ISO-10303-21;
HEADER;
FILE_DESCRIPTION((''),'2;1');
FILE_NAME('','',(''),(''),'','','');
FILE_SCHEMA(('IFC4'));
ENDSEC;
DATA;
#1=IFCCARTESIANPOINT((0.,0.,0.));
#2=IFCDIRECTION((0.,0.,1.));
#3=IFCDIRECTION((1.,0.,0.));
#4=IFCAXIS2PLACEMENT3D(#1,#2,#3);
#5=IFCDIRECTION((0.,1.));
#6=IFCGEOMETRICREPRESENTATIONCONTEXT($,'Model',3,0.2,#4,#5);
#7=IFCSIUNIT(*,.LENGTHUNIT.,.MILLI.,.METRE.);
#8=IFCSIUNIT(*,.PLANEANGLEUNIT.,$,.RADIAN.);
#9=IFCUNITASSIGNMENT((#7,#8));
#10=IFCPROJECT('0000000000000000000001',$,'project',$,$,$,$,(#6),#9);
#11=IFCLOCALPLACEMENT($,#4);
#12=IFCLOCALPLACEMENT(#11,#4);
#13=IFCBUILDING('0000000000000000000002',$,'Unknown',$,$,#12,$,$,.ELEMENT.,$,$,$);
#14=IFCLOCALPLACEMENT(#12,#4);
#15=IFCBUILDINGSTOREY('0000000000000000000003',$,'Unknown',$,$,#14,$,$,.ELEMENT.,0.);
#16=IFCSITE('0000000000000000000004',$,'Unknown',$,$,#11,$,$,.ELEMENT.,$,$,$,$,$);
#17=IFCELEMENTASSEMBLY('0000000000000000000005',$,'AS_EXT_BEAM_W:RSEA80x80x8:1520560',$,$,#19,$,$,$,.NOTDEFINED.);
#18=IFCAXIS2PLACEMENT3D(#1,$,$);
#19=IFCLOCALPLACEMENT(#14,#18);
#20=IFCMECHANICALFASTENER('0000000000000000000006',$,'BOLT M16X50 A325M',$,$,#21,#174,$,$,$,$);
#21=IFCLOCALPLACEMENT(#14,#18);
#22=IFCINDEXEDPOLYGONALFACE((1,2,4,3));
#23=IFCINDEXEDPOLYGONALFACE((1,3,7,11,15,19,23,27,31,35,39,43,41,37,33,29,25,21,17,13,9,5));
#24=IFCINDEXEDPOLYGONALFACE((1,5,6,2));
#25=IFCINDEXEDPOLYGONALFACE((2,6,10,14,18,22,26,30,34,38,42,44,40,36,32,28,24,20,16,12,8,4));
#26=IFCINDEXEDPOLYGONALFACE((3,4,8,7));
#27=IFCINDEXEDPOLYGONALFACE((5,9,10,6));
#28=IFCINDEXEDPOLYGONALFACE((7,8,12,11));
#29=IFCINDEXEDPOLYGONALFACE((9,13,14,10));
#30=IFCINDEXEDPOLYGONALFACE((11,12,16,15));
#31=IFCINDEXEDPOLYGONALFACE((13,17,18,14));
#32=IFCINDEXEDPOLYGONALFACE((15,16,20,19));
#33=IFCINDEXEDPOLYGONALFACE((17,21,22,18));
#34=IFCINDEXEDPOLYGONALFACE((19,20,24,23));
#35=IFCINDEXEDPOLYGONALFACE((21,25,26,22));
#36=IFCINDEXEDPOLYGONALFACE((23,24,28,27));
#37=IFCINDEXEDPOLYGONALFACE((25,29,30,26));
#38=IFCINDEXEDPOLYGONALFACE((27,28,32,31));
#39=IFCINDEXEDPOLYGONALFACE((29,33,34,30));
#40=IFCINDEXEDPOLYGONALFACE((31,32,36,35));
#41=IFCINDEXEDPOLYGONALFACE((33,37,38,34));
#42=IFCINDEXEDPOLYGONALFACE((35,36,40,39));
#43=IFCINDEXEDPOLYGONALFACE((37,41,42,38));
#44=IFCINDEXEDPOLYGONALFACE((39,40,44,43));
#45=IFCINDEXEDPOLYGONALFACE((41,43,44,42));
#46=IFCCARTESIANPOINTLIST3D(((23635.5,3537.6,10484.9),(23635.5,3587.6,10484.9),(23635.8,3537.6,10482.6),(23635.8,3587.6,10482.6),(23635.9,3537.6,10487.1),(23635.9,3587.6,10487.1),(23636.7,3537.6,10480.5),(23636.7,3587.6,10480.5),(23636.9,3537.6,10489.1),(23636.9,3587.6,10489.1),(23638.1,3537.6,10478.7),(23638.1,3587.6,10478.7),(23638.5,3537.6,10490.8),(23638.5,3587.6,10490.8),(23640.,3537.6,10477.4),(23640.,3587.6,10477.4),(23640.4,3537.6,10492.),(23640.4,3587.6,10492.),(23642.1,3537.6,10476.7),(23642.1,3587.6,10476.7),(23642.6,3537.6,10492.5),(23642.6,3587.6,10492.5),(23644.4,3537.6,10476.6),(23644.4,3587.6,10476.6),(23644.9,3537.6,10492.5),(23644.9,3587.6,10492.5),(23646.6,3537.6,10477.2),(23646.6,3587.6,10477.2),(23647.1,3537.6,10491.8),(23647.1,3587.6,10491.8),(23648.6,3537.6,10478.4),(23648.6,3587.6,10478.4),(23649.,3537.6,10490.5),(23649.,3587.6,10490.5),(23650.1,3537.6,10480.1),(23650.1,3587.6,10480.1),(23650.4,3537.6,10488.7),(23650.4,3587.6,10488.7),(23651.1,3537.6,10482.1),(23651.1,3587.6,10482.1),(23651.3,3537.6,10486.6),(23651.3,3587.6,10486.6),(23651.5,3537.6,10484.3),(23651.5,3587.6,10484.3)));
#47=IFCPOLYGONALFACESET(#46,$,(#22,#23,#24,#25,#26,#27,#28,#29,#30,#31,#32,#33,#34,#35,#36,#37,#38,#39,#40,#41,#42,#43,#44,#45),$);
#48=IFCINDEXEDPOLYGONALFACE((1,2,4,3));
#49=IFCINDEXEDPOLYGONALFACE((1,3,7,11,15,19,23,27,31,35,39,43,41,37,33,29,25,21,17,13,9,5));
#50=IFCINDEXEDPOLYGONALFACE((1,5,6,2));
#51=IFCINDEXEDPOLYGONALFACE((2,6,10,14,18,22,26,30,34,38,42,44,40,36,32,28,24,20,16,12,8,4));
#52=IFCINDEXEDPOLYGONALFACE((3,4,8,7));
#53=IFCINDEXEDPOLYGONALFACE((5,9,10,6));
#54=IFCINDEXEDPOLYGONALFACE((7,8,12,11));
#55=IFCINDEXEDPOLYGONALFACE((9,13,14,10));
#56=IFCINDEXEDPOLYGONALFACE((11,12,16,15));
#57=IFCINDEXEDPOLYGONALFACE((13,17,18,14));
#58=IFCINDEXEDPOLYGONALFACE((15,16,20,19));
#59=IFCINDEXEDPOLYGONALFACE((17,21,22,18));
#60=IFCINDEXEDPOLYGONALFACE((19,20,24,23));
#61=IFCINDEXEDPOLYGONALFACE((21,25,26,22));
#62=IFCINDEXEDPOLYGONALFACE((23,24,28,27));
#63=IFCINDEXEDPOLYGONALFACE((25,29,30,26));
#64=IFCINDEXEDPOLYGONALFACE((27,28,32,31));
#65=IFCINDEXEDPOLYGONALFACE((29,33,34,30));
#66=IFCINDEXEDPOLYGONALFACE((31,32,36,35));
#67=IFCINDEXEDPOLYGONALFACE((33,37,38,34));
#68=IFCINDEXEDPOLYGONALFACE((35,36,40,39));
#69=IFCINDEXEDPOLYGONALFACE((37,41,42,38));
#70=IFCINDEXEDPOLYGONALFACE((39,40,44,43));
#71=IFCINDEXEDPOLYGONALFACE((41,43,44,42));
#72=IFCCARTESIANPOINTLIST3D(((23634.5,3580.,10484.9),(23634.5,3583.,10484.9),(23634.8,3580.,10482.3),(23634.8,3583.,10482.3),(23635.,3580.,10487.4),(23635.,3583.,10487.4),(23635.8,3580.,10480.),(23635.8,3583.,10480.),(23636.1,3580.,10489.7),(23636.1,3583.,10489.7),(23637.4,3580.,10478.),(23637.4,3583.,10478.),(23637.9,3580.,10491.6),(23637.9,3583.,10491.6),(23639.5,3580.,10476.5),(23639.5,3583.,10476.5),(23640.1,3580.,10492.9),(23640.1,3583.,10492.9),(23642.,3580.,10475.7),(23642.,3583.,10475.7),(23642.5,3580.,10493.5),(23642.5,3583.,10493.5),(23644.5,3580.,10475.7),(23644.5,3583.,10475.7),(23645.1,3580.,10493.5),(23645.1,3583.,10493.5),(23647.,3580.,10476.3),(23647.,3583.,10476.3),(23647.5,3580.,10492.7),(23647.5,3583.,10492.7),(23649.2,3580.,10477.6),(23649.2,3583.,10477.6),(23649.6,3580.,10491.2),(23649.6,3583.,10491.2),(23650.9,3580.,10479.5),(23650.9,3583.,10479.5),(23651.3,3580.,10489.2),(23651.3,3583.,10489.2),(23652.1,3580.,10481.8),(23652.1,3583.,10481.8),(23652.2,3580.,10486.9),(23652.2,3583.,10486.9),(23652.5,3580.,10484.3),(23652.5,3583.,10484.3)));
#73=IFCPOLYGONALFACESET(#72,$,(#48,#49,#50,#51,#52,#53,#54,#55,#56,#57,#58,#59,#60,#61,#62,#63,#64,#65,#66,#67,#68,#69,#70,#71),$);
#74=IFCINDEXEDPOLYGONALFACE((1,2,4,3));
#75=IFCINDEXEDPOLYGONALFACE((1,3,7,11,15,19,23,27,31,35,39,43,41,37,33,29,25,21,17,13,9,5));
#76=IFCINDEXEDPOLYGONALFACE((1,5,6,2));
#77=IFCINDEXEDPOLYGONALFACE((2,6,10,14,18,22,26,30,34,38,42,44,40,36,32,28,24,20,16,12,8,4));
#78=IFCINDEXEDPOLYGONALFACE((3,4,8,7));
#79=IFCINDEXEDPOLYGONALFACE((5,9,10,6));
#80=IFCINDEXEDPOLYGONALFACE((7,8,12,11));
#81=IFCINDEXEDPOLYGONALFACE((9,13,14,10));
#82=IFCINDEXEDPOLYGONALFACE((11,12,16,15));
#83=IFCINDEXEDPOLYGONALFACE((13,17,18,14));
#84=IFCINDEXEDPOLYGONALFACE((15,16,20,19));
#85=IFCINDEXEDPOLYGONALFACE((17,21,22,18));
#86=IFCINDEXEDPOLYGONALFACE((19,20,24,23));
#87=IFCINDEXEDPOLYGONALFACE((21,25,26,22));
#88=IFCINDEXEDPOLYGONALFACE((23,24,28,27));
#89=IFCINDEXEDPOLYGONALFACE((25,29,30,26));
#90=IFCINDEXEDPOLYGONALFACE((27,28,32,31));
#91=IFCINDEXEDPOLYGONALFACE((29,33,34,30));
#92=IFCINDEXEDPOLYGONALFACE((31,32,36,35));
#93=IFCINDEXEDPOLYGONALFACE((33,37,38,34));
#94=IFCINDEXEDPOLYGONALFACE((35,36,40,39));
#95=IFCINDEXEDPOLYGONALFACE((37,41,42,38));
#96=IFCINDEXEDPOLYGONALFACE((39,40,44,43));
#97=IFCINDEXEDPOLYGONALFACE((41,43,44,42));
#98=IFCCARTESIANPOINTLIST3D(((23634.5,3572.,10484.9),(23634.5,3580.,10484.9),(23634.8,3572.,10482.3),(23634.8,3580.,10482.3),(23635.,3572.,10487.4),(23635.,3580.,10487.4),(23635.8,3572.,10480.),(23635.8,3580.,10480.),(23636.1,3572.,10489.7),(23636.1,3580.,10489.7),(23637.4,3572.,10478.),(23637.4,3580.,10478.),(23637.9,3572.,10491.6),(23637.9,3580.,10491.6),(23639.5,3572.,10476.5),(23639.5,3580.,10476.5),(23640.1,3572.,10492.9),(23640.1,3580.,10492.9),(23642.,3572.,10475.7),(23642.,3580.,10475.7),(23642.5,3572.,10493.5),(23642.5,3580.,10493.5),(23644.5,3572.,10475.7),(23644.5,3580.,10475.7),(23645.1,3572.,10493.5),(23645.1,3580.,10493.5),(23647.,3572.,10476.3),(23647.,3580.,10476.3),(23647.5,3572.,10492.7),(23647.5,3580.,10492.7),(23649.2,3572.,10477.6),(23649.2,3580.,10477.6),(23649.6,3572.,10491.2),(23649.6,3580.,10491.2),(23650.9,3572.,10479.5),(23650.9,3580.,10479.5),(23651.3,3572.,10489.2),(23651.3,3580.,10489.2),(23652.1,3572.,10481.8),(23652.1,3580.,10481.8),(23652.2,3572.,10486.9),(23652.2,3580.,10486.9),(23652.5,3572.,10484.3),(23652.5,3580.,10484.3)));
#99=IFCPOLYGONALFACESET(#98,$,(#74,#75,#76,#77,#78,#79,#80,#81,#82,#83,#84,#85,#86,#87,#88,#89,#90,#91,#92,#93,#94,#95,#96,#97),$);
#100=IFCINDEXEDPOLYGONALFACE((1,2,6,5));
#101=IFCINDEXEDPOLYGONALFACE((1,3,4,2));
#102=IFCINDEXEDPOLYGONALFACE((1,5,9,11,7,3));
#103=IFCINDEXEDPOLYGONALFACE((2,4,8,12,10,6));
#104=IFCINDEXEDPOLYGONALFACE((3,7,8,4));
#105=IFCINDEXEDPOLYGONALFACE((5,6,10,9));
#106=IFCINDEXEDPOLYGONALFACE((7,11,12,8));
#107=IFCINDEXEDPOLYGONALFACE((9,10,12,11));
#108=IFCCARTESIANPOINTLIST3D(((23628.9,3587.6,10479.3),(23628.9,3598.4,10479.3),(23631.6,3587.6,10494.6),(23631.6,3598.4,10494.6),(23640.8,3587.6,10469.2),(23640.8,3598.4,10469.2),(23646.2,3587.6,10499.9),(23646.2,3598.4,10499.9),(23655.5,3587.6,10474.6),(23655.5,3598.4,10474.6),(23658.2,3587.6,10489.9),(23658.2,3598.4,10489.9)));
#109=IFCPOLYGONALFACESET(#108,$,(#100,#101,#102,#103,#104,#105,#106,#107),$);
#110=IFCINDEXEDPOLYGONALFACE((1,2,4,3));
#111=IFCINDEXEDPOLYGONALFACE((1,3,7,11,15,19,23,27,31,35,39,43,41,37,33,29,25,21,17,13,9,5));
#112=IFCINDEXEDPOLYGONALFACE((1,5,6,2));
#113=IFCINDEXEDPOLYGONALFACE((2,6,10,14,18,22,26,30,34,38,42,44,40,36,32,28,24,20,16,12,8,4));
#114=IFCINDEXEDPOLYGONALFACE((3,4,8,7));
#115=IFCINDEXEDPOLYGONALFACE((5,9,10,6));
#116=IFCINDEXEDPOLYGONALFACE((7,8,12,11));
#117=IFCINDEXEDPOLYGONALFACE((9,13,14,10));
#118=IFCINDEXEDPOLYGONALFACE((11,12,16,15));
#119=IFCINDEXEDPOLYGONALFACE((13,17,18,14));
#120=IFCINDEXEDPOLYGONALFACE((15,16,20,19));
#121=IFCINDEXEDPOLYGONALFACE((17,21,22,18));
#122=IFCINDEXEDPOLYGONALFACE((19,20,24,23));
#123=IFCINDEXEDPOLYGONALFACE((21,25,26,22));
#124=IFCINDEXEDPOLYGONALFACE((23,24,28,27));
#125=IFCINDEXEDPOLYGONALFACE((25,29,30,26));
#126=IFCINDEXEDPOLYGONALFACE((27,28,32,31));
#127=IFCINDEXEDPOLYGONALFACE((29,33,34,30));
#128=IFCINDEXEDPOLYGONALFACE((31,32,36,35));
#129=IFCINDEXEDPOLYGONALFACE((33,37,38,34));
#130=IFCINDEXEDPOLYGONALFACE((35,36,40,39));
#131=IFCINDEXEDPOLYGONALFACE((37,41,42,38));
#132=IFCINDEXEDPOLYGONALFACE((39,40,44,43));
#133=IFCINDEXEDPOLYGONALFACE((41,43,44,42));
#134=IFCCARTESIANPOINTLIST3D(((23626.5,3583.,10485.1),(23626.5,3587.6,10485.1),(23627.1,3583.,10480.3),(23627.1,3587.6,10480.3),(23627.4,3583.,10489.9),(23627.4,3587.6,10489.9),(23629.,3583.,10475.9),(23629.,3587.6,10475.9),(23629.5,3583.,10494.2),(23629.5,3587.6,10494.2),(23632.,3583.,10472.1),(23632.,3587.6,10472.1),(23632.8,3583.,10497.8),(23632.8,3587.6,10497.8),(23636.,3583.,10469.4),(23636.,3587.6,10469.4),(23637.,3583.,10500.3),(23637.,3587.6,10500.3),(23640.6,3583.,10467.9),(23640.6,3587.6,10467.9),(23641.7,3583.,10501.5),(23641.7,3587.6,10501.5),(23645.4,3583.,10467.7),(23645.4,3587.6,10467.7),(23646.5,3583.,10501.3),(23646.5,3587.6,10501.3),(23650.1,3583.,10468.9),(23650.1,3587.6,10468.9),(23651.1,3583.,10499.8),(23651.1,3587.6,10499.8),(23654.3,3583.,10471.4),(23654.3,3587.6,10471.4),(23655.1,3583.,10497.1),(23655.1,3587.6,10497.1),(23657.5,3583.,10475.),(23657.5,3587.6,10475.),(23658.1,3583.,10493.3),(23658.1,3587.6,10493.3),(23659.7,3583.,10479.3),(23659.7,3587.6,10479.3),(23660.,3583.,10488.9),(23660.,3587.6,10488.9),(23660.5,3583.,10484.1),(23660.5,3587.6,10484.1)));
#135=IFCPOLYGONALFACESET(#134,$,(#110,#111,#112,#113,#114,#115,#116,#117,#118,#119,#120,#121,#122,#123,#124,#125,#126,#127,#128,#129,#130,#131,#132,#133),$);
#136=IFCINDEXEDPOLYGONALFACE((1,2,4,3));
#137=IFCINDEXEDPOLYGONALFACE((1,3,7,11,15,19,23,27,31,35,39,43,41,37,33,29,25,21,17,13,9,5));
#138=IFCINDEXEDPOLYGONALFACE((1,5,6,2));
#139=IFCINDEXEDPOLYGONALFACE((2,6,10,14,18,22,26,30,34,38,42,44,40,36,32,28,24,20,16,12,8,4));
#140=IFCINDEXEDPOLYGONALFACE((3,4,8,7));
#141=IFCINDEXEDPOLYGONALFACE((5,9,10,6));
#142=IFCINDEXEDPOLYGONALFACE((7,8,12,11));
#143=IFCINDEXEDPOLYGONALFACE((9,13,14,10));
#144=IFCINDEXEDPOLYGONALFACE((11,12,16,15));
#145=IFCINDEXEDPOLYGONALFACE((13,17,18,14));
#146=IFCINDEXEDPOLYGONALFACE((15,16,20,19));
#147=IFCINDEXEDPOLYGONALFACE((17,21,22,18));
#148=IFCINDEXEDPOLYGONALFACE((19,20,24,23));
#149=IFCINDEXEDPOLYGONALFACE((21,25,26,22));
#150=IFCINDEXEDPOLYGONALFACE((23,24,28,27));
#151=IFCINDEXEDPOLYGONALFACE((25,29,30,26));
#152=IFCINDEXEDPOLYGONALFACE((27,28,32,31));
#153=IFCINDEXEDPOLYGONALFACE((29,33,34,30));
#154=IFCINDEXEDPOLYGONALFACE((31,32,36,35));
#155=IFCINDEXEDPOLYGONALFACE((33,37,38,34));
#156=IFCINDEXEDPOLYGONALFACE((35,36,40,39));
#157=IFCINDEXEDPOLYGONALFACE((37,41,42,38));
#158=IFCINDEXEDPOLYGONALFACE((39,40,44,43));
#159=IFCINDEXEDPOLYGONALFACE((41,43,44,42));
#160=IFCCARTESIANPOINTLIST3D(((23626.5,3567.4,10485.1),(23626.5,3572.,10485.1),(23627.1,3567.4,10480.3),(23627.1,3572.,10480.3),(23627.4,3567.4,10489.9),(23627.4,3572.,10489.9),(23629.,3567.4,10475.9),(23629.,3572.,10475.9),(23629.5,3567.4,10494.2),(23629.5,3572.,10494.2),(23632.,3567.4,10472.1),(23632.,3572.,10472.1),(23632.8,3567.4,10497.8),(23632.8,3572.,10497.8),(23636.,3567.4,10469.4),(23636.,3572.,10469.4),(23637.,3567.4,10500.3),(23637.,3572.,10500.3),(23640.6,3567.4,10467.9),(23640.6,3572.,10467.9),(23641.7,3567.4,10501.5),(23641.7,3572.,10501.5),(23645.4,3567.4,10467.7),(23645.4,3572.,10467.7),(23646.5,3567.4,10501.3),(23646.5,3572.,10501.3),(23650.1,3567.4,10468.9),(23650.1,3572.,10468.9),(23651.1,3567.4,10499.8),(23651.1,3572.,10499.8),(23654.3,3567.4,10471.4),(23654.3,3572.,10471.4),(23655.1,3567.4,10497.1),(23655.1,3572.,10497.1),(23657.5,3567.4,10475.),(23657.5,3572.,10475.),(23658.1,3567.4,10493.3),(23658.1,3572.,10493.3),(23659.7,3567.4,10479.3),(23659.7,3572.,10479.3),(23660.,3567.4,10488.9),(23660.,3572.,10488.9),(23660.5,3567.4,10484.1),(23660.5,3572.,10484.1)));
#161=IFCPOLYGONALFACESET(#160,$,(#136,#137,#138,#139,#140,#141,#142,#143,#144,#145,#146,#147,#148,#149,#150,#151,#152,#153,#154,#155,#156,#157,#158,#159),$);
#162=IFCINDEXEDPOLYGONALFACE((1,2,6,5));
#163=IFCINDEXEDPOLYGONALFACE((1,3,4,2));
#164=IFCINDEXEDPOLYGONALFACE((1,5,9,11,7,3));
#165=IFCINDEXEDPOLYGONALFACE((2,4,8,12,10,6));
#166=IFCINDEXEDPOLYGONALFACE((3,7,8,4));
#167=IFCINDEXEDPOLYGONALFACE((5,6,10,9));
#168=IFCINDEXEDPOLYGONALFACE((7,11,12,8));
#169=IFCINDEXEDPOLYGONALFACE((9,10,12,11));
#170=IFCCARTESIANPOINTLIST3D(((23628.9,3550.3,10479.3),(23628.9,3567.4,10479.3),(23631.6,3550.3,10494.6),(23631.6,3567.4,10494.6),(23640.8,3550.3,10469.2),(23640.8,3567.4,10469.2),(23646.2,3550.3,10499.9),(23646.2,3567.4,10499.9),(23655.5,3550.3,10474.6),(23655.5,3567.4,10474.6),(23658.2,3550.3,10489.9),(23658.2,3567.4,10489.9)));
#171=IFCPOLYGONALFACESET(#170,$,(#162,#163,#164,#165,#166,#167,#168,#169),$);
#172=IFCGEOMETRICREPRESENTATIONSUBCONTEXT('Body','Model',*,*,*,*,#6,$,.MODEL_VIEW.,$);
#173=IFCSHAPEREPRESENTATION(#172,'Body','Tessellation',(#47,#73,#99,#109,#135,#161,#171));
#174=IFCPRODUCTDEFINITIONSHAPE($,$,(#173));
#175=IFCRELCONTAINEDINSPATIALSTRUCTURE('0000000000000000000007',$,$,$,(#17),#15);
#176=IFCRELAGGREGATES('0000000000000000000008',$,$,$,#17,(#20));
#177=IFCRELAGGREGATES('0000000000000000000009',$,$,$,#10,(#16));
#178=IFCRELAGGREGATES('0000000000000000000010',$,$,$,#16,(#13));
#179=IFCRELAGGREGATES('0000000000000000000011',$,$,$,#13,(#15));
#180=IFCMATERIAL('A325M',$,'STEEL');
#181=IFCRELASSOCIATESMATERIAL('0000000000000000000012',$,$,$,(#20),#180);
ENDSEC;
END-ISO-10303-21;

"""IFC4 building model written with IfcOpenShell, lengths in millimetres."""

from ifc_helpers import new_model, si_unit, direction, frame, origin_with_axes, place, context, subcontext, project, spatial, line, arc, indexed_curve, outline, extrude, source, transform, mapped, material, element, aggregate, save


model = new_model("IFC4")

# Units and contexts
model_context = context("Model", 3, precision=0.2, world=origin_with_axes(), true_north=direction((0.0, 1.0)))
body_context = subcontext(model_context, "Body", "Model", "MODEL_VIEW")
ifc_project = project(units=[si_unit("LENGTHUNIT", "METRE", prefix="MILLI"), si_unit("PLANEANGLEUNIT", "RADIAN")], contexts=[model_context])

# Site, building, storey
site_placement = place(None, origin_with_axes())
site = spatial("IfcSite", under=ifc_project, at=site_placement, Name="Unknown", CompositionType="ELEMENT")
building_placement = place(site_placement, origin_with_axes())
building = spatial("IfcBuilding", under=site, at=building_placement, Name="Unknown", CompositionType="ELEMENT")
storey_placement = place(building_placement, origin_with_axes())
storey = spatial("IfcBuildingStorey", under=building, at=storey_placement, Name="Unknown", CompositionType="ELEMENT", Elevation=0.0)

# Element assembly
assembly_1_placement = place(storey_placement, frame((23581.1, 3540.0, 10490.5), z_axis=(0.0, -1.0, 0.0), x_axis=(0.984808, 0.0, -0.173648)))
assembly_1 = element("IfcElementAssembly", 1, at=assembly_1_placement, inside=storey, Name="AS_EXT_BEAM_W:RSEA80x80x8:1520560", PredefinedType="NOTDEFINED")

# Mechanical fastener
ifc_material_1 = material(Name="A325M", Category="STEEL")
shared_shape = source(origin_with_axes(), body_context, "Body", "SweptSolid", [
    extrude(outline(indexed_curve([(8.0, 0.0), (0.0, 8.0), (-8.0, 0.0), (0.0, -8.0)], segments=[arc(1, 2, 3), arc(3, 4, 1)])), frame((0.0, 0.0, 15.6), z_axis=(0.0, 0.0, -1.0), x_axis=(0.0, 1.0, 0.0)), (0.0, 0.0, 1.0), 50.0),
    extrude(outline(indexed_curve([(9.0, 0.0), (0.0, 9.0), (-9.0, 0.0), (0.0, -9.0)], segments=[arc(1, 2, 3), arc(3, 4, 1)])), frame((0.0, 0.0, 11.0), z_axis=(0.0, 0.0, -1.0), x_axis=(0.0, 1.0, 0.0)), (0.0, 0.0, 1.0), 3.0),
    extrude(outline(indexed_curve([(9.0, 0.0), (0.0, 9.0), (-9.0, 0.0), (0.0, -9.0)], segments=[arc(1, 2, 3), arc(3, 4, 1)])), frame((0.0, 0.0, 8.0), z_axis=(0.0, 0.0, -1.0), x_axis=(0.0, 1.0, 0.0)), (0.0, 0.0, 1.0), 8.0),
    extrude(outline(indexed_curve([(15.6, 0.0), (7.8, 13.5), (-7.8, 13.5), (-15.6, 0.0), (-7.8, -13.5), (7.8, -13.5)], segments=[line(1, 2, 3, 4, 5, 6, 1)])), frame((0.0, 0.0, 26.4), z_axis=(0.0, 0.0, -1.0), x_axis=(0.0, 1.0, 0.0)), (0.0, 0.0, 1.0), 10.8),
    extrude(outline(indexed_curve([(17.0, 0.0), (0.0, 17.0), (-17.0, 0.0), (0.0, -17.0)], segments=[arc(1, 2, 3), arc(3, 4, 1)])), frame((0.0, 0.0, 15.6), z_axis=(0.0, 0.0, -1.0), x_axis=(0.0, 1.0, 0.0)), (0.0, 0.0, 1.0), 4.6),
    extrude(outline(indexed_curve([(17.0, 0.0), (0.0, 17.0), (-17.0, 0.0), (0.0, -17.0)], segments=[arc(1, 2, 3), arc(3, 4, 1)])), frame((0.0, 0.0, 0.0), z_axis=(0.0, 0.0, -1.0), x_axis=(0.0, 1.0, 0.0)), (0.0, 0.0, 1.0), 4.6),
    extrude(outline(indexed_curve([(15.6, 0.0), (7.8, 13.5), (-7.8, 13.5), (-15.6, 0.0), (-7.8, -13.5), (7.8, -13.5)], segments=[line(1, 2, 3, 4, 5, 6, 1)])), frame((0.0, 0.0, -4.6), z_axis=(0.0, 0.0, -1.0), x_axis=(0.0, 1.0, 0.0)), (0.0, 0.0, 1.0), 17.1),
])
mechanical_fastener_1_placement = place(assembly_1_placement, frame((62.5, 5.0, -32.0), z_axis=(0.0, 0.0, -1.0), x_axis=(1.0, 0.0, 0.0)))
mechanical_fastener_1 = element("IfcMechanicalFastener", 2, at=mechanical_fastener_1_placement, material=ifc_material_1, Name="BOLT M16X50 A325M", context=body_context, shape_type="MappedRepresentation", body=[
    mapped(shared_shape, transform((0.0, 0.0, 0.0))),
])
aggregate(assembly_1, [mechanical_fastener_1])

save(model, "model.ifc")
